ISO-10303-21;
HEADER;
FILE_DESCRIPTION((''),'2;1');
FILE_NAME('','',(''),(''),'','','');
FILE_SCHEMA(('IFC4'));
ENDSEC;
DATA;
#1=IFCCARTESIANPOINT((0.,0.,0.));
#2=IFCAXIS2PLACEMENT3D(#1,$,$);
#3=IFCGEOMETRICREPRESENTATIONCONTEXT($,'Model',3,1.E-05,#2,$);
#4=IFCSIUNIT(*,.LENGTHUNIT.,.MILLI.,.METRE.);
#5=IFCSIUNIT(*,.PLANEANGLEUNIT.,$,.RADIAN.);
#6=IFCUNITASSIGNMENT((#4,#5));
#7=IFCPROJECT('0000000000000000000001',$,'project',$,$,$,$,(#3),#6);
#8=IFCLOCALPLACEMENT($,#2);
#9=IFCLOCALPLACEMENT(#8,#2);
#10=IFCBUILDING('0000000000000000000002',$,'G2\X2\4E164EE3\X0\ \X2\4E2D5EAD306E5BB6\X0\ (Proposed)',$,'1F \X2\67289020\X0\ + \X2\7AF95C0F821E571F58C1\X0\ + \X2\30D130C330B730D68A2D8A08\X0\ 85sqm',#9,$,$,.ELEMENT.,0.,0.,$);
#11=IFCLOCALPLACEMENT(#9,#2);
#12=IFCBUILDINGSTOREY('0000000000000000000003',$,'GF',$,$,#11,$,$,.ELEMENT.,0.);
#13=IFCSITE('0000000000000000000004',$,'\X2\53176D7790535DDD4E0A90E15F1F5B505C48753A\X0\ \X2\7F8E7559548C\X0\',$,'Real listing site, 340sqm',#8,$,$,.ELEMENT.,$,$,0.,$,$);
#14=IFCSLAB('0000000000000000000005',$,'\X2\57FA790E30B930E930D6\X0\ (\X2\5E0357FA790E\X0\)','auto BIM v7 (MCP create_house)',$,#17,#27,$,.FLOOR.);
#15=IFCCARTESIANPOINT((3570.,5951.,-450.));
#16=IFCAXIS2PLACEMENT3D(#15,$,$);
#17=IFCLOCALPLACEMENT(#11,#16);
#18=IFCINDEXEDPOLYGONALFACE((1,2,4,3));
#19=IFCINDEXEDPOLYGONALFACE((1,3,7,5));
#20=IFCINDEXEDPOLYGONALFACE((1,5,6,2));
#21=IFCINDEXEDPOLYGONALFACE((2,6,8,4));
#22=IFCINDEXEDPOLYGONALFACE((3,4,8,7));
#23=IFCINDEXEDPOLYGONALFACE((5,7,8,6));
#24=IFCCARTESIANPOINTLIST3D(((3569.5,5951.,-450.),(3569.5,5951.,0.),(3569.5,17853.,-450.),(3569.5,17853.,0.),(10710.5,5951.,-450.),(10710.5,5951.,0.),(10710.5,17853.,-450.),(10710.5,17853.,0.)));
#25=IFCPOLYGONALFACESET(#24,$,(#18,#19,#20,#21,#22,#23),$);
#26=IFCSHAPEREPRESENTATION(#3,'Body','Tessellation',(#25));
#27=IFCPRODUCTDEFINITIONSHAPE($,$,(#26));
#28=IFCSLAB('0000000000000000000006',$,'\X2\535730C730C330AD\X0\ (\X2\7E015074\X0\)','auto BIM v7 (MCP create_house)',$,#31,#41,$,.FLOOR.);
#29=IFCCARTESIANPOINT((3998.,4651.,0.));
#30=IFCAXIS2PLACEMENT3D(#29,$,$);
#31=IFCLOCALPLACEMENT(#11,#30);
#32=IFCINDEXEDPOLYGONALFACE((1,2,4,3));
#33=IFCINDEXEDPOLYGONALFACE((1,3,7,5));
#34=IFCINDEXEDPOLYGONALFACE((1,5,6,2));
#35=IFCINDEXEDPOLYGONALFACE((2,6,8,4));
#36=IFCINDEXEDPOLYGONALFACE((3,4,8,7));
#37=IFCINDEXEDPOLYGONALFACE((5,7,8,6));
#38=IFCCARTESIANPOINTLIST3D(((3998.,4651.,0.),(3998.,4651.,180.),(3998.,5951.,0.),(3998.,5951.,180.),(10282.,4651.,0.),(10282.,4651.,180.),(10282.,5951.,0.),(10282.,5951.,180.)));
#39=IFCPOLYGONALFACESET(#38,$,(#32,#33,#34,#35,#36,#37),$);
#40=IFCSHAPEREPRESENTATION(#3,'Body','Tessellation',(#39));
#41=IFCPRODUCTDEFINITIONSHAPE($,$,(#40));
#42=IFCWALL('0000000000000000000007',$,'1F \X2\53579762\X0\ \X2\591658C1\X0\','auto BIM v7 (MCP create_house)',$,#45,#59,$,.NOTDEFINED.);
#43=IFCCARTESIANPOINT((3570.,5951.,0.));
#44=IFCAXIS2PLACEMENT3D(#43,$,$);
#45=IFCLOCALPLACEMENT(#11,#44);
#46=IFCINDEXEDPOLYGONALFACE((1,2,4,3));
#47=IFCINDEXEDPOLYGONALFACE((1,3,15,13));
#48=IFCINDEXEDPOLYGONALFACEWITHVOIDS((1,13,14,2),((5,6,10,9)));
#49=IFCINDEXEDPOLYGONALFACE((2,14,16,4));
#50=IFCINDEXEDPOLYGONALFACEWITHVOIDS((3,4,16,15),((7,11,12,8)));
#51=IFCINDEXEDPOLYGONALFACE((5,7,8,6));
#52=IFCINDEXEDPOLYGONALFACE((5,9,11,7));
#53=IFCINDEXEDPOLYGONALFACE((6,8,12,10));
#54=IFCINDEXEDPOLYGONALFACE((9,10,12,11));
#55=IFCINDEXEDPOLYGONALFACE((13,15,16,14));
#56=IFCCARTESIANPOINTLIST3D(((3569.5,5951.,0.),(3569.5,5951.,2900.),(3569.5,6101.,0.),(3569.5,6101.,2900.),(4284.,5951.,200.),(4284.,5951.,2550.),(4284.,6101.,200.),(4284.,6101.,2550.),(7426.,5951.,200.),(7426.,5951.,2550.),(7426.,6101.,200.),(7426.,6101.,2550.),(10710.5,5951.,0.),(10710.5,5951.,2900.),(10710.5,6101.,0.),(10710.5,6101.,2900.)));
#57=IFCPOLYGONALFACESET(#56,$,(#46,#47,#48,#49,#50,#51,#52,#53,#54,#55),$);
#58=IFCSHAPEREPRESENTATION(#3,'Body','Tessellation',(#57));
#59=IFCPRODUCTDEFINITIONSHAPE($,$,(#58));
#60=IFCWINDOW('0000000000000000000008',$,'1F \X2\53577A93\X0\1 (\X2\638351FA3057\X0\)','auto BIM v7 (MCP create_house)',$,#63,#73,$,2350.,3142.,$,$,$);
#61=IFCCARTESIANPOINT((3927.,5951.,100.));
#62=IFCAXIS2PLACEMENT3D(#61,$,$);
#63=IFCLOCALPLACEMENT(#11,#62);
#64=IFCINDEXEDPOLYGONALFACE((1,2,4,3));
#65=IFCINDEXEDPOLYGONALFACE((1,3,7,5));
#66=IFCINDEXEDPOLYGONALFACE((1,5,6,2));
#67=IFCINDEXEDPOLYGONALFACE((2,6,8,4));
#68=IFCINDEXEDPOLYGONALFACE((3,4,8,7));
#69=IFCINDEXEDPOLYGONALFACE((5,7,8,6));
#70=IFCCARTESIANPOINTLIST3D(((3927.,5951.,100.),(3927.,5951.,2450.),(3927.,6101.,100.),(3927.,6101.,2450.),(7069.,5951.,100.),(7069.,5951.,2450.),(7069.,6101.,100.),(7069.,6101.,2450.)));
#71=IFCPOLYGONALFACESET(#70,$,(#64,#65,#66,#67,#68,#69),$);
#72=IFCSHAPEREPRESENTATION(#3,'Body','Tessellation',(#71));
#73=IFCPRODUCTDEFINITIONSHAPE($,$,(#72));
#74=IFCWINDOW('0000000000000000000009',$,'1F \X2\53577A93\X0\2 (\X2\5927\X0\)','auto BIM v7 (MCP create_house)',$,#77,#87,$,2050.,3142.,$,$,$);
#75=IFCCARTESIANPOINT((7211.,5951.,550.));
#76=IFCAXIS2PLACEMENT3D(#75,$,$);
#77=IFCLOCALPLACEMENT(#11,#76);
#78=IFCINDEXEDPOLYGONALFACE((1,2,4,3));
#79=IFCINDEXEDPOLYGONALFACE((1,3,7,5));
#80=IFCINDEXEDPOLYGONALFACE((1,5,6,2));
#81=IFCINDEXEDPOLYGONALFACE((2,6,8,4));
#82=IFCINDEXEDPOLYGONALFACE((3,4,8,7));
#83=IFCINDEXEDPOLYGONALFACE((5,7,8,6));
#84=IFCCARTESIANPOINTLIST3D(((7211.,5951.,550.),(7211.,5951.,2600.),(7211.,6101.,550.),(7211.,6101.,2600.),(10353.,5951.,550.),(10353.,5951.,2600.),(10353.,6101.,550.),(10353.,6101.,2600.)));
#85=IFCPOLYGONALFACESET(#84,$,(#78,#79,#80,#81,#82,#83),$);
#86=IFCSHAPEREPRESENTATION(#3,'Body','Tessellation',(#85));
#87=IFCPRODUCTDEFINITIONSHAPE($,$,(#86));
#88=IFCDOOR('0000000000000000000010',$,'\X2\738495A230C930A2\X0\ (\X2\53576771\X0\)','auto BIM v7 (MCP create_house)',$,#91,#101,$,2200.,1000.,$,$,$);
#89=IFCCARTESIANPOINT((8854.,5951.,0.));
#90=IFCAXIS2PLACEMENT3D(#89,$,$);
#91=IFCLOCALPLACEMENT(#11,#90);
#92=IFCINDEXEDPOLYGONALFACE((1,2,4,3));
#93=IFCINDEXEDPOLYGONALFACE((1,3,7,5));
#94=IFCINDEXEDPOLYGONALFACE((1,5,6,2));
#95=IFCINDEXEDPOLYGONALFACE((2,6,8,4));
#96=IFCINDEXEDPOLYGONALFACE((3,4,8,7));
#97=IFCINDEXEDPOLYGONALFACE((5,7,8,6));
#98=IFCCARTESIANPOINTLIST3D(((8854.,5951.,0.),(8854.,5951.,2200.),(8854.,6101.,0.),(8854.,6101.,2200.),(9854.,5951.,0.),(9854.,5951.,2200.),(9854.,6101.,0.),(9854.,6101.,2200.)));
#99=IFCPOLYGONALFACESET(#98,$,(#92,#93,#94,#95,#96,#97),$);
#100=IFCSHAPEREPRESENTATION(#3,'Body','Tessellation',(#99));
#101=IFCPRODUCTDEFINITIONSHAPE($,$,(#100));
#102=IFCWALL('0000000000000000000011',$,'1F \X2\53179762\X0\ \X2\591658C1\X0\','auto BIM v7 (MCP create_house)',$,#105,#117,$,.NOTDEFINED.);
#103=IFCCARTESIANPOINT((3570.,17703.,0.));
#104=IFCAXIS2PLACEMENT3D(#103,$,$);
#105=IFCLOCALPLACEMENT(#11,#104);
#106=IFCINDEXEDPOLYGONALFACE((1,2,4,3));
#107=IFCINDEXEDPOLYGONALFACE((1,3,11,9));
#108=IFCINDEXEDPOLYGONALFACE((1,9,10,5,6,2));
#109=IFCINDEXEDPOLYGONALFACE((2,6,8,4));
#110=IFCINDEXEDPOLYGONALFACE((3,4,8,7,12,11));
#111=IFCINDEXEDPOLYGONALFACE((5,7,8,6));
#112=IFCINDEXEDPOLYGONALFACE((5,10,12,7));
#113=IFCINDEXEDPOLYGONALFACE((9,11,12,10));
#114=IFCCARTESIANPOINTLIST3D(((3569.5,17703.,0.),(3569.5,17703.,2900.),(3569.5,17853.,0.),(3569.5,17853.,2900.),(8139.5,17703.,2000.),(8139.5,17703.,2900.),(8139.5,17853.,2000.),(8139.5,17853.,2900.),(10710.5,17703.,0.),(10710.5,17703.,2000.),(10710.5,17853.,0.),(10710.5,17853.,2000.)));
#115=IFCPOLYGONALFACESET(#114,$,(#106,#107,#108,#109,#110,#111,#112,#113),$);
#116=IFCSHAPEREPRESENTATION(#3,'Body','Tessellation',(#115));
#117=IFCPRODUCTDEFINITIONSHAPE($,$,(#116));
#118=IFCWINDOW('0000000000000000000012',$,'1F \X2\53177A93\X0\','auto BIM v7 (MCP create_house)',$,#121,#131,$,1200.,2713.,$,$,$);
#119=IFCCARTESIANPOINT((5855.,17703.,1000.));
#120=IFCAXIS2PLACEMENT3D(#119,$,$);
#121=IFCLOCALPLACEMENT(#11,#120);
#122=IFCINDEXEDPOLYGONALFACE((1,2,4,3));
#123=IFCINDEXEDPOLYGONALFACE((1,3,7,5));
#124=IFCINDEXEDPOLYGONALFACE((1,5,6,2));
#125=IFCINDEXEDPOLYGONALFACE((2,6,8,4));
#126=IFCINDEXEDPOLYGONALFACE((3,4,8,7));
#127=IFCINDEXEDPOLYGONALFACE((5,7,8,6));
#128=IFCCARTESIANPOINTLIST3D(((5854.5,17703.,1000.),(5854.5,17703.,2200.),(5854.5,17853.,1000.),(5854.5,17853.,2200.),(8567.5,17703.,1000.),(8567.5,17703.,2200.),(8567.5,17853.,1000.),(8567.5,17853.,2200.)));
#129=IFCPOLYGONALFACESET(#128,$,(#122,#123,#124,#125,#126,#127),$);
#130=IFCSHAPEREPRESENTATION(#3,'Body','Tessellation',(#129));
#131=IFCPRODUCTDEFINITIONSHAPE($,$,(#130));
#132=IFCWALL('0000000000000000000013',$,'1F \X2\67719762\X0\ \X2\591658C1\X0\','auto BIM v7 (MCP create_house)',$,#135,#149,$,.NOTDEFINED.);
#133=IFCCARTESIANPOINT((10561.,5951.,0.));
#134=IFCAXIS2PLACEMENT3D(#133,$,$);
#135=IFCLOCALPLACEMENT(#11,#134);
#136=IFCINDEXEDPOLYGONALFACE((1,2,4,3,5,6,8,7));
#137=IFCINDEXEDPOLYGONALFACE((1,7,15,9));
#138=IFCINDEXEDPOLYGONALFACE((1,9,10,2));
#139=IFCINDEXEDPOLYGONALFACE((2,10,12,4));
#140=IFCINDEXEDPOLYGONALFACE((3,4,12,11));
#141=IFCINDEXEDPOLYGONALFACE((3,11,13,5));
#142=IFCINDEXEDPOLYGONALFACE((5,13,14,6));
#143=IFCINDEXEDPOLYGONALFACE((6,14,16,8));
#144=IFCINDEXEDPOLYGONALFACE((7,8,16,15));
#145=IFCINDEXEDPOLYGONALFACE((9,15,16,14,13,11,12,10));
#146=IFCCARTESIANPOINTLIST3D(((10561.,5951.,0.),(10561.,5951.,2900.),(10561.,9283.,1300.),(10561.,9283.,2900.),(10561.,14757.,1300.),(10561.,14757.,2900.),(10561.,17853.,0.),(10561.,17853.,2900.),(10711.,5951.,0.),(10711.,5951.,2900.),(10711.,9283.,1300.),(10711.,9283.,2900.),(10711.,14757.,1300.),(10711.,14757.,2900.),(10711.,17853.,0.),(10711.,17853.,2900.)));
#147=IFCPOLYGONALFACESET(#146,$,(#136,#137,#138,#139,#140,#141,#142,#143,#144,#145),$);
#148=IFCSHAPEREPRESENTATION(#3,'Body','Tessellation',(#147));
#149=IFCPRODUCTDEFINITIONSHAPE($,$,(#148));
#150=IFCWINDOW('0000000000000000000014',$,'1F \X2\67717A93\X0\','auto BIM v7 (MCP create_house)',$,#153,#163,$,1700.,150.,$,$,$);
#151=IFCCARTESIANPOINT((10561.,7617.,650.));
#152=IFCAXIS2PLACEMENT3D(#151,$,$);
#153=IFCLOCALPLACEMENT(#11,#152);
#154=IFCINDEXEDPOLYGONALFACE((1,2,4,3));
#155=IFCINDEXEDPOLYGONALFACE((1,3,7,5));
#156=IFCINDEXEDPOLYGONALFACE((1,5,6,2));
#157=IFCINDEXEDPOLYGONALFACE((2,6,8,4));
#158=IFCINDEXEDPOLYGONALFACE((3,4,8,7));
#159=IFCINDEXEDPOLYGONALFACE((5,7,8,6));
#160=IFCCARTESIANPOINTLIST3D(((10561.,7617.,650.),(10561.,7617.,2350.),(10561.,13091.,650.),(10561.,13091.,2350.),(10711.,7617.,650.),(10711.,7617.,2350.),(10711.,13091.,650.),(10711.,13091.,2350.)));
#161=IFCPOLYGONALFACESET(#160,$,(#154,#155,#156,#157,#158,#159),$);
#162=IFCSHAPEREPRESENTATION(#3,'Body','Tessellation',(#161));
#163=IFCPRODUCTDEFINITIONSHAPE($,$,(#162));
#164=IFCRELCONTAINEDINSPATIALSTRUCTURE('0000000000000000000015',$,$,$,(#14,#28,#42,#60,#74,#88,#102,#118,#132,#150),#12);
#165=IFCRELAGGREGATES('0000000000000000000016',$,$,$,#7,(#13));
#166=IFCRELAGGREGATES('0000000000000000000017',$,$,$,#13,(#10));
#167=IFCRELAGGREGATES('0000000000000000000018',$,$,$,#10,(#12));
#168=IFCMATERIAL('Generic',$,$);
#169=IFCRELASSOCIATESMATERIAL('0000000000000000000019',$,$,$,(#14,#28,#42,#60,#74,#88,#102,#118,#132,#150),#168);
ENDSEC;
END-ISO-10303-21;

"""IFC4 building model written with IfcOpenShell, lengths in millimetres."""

from ifc_helpers import new_model, si_unit, frame, frame_2d, origin, place, context, project, spatial, rectangle, extrude, material, element, fill, save


model = new_model("IFC4")

# Units and contexts
model_context = context("Model", 3, precision=1e-05, world=origin())
ifc_project = project(units=[si_unit("LENGTHUNIT", "METRE", prefix="MILLI"), si_unit("PLANEANGLEUNIT", "RADIAN")], contexts=[model_context])

# Site, building, storey
site_placement = place(None, origin())
site = spatial("IfcSite", under=ifc_project, at=site_placement, Name="北海道川上郡弟子屈町 美留和", ObjectType="Real listing site, 340sqm", CompositionType="ELEMENT", RefElevation=0.0)
building_placement = place(site_placement, origin())
building = spatial("IfcBuilding", under=site, at=building_placement, Name="G2世代 中庭の家 (Proposed)", ObjectType="1F 木造 + 竹小舞土壁 + パッシブ設計 85sqm", CompositionType="ELEMENT", ElevationOfRefHeight=0.0, ElevationOfTerrain=0.0)
storey_placement = place(building_placement, origin())
storey = spatial("IfcBuildingStorey", under=building, at=storey_placement, Name="GF", CompositionType="ELEMENT", Elevation=0.0)

# Slabs
ifc_material = material(Name="Generic")
slab_1_placement = place(storey_placement, frame((3570.0, 5951.0, -450.0)))
element("IfcSlab", 1, at=slab_1_placement, inside=storey, material=ifc_material, Name="基礎スラブ (布基礎)", Description="auto BIM v7 (MCP create_house)", PredefinedType="FLOOR", context=model_context, shape_type="SweptSolid", body=[
    extrude(rectangle(XDim=7141.0, YDim=11902.0, at=frame_2d((3570.0, 5951.0))), frame((3570.0, 5951.0, -450.0)), (0.0, 0.0, 1.0), 450.0),
])
slab_2_placement = place(storey_placement, frame((3998.0, 4651.0, 0.0)))
element("IfcSlab", 2, at=slab_2_placement, inside=storey, material=ifc_material, Name="南デッキ (縁側)", Description="auto BIM v7 (MCP create_house)", PredefinedType="FLOOR", context=model_context, shape_type="SweptSolid", body=[
    extrude(rectangle(XDim=6284.0, YDim=1300.0, at=frame_2d((3142.0, 650.0))), frame((3998.0, 4651.0, 0.0)), (0.0, 0.0, 1.0), 180.0),
])

# Wall, openings, windows, door
wall_1_placement = place(storey_placement, frame((3570.0, 5951.0, 0.0)))
wall_1 = element("IfcWall", 3, at=wall_1_placement, inside=storey, material=ifc_material, Name="1F 南面 外壁", Description="auto BIM v7 (MCP create_house)", PredefinedType="NOTDEFINED", context=model_context, shape_type="SweptSolid", body=[
    extrude(rectangle(XDim=7141.0, YDim=150.0, at=frame_2d((3570.0, 75.0))), frame((3570.0, 5951.0, 0.0)), (0.0, 0.0, 1.0), 2900.0),
])
opening_1_placement = place(storey_placement, frame((3927.0, 5951.0, 100.0)))
opening_1 = element("IfcOpeningElement", 4, at=opening_1_placement, cuts=wall_1, PredefinedType="NOTDEFINED", context=model_context, shape_type="SweptSolid", body=[
    extrude(rectangle(XDim=3142.0, YDim=150.0, at=frame_2d((1571.0, 75.0))), frame((3927.0, 5951.0, 100.0)), (0.0, 0.0, 1.0), 2350.0),
])
opening_2_placement = place(storey_placement, frame((7211.0, 5951.0, 550.0)))
opening_2 = element("IfcOpeningElement", 5, at=opening_2_placement, cuts=wall_1, PredefinedType="NOTDEFINED", context=model_context, shape_type="SweptSolid", body=[
    extrude(rectangle(XDim=3142.0, YDim=150.0, at=frame_2d((1571.0, 75.0))), frame((7211.0, 5951.0, 550.0)), (0.0, 0.0, 1.0), 2050.0),
])
opening_3_placement = place(storey_placement, frame((8854.0, 5951.0, 0.0)))
opening_3 = element("IfcOpeningElement", 6, at=opening_3_placement, cuts=wall_1, PredefinedType="NOTDEFINED", context=model_context, shape_type="SweptSolid", body=[
    extrude(rectangle(XDim=1000.0, YDim=150.0, at=frame_2d((500.0, 75.0))), frame((8854.0, 5951.0, 0.0)), (0.0, 0.0, 1.0), 2200.0),
])
window_1_placement = place(storey_placement, frame((3927.0, 5951.0, 100.0)))
window_1 = element("IfcWindow", 7, at=window_1_placement, inside=storey, material=ifc_material, Name="1F 南窓1 (掃出し)", Description="auto BIM v7 (MCP create_house)", OverallHeight=2350.0, OverallWidth=3142.0, context=model_context, shape_type="SweptSolid", body=[
    extrude(rectangle(XDim=3142.0, YDim=150.0, at=frame_2d((1571.0, 75.0))), frame((3927.0, 5951.0, 100.0)), (0.0, 0.0, 1.0), 2350.0),
])
fill(opening_1, window_1)
window_2_placement = place(storey_placement, frame((7211.0, 5951.0, 550.0)))
window_2 = element("IfcWindow", 8, at=window_2_placement, inside=storey, material=ifc_material, Name="1F 南窓2 (大)", Description="auto BIM v7 (MCP create_house)", OverallHeight=2050.0, OverallWidth=3142.0, context=model_context, shape_type="SweptSolid", body=[
    extrude(rectangle(XDim=3142.0, YDim=150.0, at=frame_2d((1571.0, 75.0))), frame((7211.0, 5951.0, 550.0)), (0.0, 0.0, 1.0), 2050.0),
])
fill(opening_2, window_2)
door_placement = place(storey_placement, frame((8854.0, 5951.0, 0.0)))
door = element("IfcDoor", 9, at=door_placement, inside=storey, material=ifc_material, Name="玄関ドア (南東)", Description="auto BIM v7 (MCP create_house)", OverallHeight=2200.0, OverallWidth=1000.0, context=model_context, shape_type="SweptSolid", body=[
    extrude(rectangle(XDim=1000.0, YDim=150.0, at=frame_2d((500.0, 75.0))), frame((8854.0, 5951.0, 0.0)), (0.0, 0.0, 1.0), 2200.0),
])
fill(opening_3, door)

# Walls, openings, windows
wall_2_placement = place(storey_placement, frame((3570.0, 17703.0, 0.0)))
wall_2 = element("IfcWall", 10, at=wall_2_placement, inside=storey, material=ifc_material, Name="1F 北面 外壁", Description="auto BIM v7 (MCP create_house)", PredefinedType="NOTDEFINED", context=model_context, shape_type="SweptSolid", body=[
    extrude(rectangle(XDim=7141.0, YDim=150.0, at=frame_2d((3570.0, 75.0))), frame((3570.0, 17703.0, 0.0)), (0.0, 0.0, 1.0), 2900.0),
])
opening_4_placement = place(storey_placement, frame((5855.0, 17703.0, 1000.0)))
opening_4 = element("IfcOpeningElement", 11, at=opening_4_placement, cuts=wall_2, PredefinedType="NOTDEFINED", context=model_context, shape_type="SweptSolid", body=[
    extrude(rectangle(XDim=2713.0, YDim=150.0, at=frame_2d((1356.0, 75.0))), frame((5855.0, 17703.0, 1000.0)), (0.0, 0.0, 1.0), 1200.0),
])
window_3_placement = place(storey_placement, frame((5855.0, 17703.0, 1000.0)))
window_3 = element("IfcWindow", 12, at=window_3_placement, inside=storey, material=ifc_material, Name="1F 北窓", Description="auto BIM v7 (MCP create_house)", OverallHeight=1200.0, OverallWidth=2713.0, context=model_context, shape_type="SweptSolid", body=[
    extrude(rectangle(XDim=2713.0, YDim=150.0, at=frame_2d((1356.0, 75.0))), frame((5855.0, 17703.0, 1000.0)), (0.0, 0.0, 1.0), 1200.0),
])
fill(opening_4, window_3)
wall_3_placement = place(storey_placement, frame((10561.0, 5951.0, 0.0)))
wall_3 = element("IfcWall", 13, at=wall_3_placement, inside=storey, material=ifc_material, Name="1F 東面 外壁", Description="auto BIM v7 (MCP create_house)", PredefinedType="NOTDEFINED", context=model_context, shape_type="SweptSolid", body=[
    extrude(rectangle(XDim=150.0, YDim=11902.0, at=frame_2d((75.0, 5951.0))), frame((10561.0, 5951.0, 0.0)), (0.0, 0.0, 1.0), 2900.0),
])
opening_5_placement = place(storey_placement, frame((10561.0, 7617.0, 650.0)))
opening_5 = element("IfcOpeningElement", 14, at=opening_5_placement, cuts=wall_3, PredefinedType="NOTDEFINED", context=model_context, shape_type="SweptSolid", body=[
    extrude(rectangle(XDim=150.0, YDim=5474.0, at=frame_2d((75.0, 2737.0))), frame((10561.0, 7617.0, 650.0)), (0.0, 0.0, 1.0), 1700.0),
])
window_4_placement = place(storey_placement, frame((10561.0, 7617.0, 650.0)))
window_4 = element("IfcWindow", 15, at=window_4_placement, inside=storey, material=ifc_material, Name="1F 東窓", Description="auto BIM v7 (MCP create_house)", OverallHeight=1700.0, OverallWidth=150.0, context=model_context, shape_type="SweptSolid", body=[
    extrude(rectangle(XDim=150.0, YDim=5474.0, at=frame_2d((75.0, 2737.0))), frame((10561.0, 7617.0, 650.0)), (0.0, 0.0, 1.0), 1700.0),
])
fill(opening_5, window_4)

save(model, "model.ifc")
